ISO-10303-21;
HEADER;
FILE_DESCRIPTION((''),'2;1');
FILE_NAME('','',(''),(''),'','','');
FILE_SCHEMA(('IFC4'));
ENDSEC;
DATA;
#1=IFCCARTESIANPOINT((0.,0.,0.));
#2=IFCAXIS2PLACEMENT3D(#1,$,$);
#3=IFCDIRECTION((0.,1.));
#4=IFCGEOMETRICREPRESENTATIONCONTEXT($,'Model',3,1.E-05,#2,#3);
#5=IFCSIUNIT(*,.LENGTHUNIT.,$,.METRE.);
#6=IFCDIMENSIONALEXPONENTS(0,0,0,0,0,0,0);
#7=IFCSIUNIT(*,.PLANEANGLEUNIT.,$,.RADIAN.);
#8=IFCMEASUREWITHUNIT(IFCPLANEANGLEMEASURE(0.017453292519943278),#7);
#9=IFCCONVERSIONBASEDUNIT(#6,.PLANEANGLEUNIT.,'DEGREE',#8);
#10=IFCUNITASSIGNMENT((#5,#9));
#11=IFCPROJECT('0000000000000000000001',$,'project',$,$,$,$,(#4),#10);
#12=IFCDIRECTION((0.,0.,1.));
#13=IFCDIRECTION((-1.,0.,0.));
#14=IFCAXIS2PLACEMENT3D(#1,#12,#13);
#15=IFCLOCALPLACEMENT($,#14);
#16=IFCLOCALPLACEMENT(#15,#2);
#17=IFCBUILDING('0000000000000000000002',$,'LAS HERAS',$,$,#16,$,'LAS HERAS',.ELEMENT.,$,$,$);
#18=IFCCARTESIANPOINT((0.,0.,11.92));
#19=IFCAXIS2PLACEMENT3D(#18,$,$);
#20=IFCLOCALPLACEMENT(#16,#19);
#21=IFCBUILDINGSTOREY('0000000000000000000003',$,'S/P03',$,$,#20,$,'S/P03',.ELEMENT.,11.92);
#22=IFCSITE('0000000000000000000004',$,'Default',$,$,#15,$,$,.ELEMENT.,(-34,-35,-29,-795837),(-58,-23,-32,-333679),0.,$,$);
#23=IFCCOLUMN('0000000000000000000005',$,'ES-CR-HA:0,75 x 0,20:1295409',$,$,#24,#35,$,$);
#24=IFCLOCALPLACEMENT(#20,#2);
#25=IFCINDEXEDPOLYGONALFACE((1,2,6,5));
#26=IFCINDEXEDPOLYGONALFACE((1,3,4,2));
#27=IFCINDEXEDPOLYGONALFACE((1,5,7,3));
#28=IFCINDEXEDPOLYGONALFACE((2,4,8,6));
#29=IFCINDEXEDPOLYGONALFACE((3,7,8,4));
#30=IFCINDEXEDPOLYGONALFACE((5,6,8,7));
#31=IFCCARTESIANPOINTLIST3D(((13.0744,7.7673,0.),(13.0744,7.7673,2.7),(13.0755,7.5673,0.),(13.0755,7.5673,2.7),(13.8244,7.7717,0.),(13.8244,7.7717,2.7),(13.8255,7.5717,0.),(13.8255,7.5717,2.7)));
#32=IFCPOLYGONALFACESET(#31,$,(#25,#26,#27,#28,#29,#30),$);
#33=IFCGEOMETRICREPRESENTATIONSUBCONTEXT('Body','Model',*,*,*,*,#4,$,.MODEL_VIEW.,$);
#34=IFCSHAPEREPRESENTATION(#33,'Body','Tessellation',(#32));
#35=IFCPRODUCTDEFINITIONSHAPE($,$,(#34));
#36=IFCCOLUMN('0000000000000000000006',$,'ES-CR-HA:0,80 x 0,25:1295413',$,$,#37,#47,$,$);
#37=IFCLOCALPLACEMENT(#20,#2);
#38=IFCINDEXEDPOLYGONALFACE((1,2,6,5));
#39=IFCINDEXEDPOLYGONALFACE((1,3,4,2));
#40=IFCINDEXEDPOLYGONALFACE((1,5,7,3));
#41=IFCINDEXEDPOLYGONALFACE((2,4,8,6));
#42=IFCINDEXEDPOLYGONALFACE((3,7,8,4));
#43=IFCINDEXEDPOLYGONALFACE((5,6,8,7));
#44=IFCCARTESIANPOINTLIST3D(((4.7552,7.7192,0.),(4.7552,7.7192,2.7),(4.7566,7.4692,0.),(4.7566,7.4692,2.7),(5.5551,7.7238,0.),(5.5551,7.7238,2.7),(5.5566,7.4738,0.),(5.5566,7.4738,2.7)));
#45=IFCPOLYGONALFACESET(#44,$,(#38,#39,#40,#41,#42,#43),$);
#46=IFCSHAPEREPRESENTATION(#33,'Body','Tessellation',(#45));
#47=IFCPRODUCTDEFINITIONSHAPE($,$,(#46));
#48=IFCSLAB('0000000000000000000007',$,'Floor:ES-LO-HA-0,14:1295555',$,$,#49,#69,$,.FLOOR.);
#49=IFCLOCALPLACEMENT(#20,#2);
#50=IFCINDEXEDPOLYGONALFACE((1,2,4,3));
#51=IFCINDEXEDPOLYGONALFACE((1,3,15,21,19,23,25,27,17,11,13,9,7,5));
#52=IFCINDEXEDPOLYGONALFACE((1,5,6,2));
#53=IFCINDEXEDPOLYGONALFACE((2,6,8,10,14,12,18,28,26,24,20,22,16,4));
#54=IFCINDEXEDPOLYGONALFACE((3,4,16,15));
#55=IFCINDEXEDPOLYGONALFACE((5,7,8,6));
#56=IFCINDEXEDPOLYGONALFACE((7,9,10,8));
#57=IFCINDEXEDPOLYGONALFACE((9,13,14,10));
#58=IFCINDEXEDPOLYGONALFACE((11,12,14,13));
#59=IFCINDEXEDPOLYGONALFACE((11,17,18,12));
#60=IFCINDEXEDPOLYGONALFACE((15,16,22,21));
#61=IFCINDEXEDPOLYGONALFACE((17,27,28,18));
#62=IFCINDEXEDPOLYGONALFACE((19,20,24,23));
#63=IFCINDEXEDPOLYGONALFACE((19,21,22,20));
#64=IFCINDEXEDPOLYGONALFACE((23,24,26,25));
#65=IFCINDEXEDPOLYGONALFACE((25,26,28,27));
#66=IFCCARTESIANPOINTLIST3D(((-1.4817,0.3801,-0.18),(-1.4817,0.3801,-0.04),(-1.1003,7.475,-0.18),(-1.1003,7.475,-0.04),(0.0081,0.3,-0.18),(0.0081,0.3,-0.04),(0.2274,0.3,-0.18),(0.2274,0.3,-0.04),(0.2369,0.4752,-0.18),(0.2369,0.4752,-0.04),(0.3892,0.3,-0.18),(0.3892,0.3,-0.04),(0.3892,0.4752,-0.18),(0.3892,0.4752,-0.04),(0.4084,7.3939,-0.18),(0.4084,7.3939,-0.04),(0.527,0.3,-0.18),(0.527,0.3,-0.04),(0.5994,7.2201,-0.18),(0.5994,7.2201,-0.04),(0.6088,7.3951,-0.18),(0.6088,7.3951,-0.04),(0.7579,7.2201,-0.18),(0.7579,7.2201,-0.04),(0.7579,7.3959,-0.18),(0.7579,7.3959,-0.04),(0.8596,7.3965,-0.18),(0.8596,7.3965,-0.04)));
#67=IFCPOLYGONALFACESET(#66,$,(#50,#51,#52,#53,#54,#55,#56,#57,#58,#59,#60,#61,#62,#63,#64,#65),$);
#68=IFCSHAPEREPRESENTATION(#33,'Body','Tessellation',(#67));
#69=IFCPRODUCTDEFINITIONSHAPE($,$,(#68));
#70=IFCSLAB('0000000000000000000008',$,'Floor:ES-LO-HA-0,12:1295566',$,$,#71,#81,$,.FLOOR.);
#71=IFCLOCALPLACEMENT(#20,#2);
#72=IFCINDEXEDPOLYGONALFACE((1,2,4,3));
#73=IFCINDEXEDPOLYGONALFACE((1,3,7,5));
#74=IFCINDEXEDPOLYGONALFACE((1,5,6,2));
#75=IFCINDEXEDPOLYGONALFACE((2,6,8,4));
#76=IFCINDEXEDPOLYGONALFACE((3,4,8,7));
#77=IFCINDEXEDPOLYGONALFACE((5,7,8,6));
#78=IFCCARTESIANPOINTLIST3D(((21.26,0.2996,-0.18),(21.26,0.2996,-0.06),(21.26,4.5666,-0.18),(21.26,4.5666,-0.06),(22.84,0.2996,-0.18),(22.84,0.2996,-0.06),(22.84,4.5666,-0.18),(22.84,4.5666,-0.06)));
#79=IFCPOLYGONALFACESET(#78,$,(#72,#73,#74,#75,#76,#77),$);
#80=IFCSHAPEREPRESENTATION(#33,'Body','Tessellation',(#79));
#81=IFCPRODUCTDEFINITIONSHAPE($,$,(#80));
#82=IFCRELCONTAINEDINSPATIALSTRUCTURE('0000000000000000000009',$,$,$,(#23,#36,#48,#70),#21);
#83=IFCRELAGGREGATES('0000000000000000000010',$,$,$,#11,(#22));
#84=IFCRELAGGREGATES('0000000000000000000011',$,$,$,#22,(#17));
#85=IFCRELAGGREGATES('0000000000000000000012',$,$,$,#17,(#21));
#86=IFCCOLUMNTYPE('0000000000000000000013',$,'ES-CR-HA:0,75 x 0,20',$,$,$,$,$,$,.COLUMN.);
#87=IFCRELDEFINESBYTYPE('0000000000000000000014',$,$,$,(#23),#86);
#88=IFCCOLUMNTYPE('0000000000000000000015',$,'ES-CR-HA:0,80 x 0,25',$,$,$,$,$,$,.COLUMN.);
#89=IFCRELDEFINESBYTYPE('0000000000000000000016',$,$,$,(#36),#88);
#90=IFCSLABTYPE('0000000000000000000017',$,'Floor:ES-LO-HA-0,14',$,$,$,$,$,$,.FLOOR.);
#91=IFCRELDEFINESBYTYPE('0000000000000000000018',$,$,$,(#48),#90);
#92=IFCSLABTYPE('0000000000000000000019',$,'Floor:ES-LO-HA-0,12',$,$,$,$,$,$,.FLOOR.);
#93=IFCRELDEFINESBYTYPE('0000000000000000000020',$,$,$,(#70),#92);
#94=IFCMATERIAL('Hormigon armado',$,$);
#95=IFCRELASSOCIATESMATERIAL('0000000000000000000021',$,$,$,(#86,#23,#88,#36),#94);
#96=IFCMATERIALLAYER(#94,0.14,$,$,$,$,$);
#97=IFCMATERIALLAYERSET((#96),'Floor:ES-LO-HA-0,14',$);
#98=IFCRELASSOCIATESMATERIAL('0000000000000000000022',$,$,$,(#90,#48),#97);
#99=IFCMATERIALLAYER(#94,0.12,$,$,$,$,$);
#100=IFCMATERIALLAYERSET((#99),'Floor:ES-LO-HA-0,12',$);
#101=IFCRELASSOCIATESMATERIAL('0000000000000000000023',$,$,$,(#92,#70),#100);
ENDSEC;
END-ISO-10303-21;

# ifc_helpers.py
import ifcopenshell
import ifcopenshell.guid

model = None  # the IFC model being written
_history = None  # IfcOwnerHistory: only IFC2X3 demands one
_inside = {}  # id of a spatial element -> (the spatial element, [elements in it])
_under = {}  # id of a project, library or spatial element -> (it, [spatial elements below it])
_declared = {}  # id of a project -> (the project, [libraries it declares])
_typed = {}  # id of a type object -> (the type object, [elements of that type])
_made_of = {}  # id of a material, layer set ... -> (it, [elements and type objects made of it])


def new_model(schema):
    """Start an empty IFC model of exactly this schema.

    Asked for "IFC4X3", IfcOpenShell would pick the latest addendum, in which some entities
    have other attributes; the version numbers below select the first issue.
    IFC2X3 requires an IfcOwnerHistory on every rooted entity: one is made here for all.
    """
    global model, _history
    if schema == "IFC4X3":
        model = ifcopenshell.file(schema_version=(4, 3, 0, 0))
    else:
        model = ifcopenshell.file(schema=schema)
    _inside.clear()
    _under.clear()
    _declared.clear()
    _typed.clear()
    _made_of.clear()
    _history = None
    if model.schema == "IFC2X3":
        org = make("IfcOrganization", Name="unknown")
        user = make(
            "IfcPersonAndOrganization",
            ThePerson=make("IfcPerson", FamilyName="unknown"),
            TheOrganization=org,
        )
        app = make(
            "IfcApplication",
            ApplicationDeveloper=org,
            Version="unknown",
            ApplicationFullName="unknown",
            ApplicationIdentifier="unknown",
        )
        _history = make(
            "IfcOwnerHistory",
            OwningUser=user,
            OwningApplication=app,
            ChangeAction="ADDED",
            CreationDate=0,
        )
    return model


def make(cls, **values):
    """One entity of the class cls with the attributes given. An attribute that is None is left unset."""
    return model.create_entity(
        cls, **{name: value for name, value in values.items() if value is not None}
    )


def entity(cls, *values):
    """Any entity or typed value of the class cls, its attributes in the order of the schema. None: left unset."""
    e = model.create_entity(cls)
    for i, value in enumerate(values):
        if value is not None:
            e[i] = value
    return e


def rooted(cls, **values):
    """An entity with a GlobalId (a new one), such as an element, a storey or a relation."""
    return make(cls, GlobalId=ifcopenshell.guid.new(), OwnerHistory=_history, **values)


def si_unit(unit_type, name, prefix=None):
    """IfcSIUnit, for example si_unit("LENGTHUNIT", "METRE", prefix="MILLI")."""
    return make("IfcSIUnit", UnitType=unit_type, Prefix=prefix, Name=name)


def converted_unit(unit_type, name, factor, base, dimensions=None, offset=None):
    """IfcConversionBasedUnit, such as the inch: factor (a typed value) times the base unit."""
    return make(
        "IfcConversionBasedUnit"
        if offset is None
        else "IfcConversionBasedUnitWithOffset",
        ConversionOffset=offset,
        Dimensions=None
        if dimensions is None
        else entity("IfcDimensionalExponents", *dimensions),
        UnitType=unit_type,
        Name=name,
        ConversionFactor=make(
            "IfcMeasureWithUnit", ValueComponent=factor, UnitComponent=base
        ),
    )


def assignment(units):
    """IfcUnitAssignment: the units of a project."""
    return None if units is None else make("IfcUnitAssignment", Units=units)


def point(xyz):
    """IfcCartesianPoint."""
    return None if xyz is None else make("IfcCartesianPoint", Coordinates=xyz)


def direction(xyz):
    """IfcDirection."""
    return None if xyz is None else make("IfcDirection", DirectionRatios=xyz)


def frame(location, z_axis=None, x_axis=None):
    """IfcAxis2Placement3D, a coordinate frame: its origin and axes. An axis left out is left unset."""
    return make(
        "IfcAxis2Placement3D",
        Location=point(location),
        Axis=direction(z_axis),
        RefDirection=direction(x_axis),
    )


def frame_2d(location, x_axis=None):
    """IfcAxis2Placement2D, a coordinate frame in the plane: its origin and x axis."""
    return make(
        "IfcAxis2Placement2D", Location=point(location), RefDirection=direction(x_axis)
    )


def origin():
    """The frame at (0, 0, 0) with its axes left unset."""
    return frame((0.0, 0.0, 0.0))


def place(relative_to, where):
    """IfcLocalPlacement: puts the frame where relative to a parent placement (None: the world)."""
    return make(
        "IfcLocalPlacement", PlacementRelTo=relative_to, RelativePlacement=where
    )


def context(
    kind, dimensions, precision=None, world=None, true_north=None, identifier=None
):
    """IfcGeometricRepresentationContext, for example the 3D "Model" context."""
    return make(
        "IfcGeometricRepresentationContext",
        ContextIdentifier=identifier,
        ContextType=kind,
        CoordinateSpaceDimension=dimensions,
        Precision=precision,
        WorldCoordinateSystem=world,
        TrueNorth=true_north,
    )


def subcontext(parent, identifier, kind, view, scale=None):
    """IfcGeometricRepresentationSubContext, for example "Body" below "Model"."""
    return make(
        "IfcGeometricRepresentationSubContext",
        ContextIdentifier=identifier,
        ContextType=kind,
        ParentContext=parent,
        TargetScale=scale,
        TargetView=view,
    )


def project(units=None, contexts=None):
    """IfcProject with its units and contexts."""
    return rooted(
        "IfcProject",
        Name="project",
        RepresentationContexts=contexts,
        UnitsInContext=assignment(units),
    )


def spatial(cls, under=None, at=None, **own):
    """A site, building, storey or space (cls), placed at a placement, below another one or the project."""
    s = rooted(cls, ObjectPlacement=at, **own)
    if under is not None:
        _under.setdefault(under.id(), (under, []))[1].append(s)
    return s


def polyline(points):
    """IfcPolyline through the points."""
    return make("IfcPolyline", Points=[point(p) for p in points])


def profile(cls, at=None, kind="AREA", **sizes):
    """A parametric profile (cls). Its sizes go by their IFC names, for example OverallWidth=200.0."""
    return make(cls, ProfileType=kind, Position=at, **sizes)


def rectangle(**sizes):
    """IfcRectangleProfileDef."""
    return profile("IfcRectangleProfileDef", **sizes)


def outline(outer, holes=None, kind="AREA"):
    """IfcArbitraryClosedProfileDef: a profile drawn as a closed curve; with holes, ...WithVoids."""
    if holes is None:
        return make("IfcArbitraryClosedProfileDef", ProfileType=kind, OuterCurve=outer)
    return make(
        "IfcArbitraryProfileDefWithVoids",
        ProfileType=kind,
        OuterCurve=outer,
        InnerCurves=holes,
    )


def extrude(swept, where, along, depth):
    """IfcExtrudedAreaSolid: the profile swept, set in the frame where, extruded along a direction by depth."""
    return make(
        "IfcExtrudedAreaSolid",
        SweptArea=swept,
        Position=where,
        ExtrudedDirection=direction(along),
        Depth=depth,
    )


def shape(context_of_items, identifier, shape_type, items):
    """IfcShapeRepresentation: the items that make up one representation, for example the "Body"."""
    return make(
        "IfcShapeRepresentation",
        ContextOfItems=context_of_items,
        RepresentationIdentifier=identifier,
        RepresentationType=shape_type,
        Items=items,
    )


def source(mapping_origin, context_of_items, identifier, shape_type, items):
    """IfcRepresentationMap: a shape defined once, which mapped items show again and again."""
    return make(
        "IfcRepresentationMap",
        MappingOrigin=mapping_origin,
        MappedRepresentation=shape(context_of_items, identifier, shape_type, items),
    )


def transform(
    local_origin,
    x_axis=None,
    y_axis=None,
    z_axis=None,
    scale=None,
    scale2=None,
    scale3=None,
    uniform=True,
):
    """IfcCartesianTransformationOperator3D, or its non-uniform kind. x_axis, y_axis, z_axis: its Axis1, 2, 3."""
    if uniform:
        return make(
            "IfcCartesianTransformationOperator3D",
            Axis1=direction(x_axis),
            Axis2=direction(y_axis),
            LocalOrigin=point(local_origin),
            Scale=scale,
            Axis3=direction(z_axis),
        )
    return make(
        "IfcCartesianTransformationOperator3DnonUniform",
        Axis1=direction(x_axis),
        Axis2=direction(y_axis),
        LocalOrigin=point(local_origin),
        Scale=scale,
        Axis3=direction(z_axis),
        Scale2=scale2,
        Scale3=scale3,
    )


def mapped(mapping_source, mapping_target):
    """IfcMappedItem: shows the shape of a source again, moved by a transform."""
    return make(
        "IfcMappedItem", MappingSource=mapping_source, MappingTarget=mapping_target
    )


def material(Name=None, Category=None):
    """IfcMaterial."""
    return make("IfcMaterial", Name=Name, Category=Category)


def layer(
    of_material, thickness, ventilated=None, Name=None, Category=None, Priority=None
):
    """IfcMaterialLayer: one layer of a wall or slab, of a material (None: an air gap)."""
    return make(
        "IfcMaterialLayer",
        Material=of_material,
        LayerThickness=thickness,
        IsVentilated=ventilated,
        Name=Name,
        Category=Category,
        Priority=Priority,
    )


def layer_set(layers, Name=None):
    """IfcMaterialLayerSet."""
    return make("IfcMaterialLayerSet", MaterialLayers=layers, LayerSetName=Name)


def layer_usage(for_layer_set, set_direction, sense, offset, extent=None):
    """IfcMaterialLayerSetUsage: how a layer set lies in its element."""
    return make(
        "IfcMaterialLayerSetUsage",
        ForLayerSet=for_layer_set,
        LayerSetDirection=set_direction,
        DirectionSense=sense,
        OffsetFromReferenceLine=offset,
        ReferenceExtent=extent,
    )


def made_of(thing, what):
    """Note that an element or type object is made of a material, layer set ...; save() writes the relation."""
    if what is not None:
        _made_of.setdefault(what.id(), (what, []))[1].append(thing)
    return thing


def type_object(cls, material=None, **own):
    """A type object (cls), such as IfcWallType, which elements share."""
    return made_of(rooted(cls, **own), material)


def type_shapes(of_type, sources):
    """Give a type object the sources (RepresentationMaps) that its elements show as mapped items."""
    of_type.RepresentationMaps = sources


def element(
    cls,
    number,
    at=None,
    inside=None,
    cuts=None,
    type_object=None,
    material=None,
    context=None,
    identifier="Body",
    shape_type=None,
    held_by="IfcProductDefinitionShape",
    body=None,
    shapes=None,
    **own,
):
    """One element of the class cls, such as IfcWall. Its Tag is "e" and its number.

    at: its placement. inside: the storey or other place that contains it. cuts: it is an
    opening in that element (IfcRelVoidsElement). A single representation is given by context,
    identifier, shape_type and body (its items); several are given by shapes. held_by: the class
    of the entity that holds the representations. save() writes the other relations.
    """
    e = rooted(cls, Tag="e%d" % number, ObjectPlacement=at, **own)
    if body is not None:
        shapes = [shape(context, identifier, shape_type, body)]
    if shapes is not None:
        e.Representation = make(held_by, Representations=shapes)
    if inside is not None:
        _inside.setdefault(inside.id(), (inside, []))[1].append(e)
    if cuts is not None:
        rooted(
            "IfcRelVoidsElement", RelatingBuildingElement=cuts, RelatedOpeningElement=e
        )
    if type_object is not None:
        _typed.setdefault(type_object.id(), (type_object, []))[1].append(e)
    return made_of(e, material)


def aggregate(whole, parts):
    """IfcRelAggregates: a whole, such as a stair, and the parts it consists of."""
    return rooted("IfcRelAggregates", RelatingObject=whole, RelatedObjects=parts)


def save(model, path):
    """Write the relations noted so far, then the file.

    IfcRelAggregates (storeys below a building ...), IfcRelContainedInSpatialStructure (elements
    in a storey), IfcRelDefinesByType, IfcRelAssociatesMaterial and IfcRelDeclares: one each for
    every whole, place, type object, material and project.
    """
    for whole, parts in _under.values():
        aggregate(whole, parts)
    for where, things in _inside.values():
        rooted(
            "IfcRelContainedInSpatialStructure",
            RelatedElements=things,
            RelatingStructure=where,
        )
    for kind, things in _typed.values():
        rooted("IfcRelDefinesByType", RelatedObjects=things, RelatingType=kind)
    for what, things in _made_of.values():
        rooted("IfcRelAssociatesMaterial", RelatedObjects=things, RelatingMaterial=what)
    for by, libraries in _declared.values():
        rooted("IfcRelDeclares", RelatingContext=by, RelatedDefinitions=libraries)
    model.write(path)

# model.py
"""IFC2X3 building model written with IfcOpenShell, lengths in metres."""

from ifc_helpers import new_model, entity, si_unit, converted_unit, direction, frame, frame_2d, origin, place, context, subcontext, project, spatial, polyline, rectangle, outline, extrude, source, transform, mapped, material, layer, layer_set, layer_usage, type_object, type_shapes, element, save


model = new_model("IFC2X3")

# Units and contexts
model_context = context("Model", 3, precision=1e-05, world=origin(), true_north=direction((0.0, 1.0)))
body_context = subcontext(model_context, "Body", "Model", "MODEL_VIEW")
ifc_project = project(units=[si_unit("LENGTHUNIT", "METRE"), converted_unit("PLANEANGLEUNIT", "DEGREE", entity("IfcPlaneAngleMeasure", 0.017453292519943278), si_unit("PLANEANGLEUNIT", "RADIAN"), dimensions=[0, 0, 0, 0, 0, 0, 0])], contexts=[model_context])

# Site, building, storey
site_placement = place(None, frame((0.0, 0.0, 0.0), z_axis=(0.0, 0.0, 1.0), x_axis=(-1.0, 0.0, 0.0)))
site = spatial("IfcSite", under=ifc_project, at=site_placement, Name="Default", CompositionType="ELEMENT", RefLatitude=(-34, -35, -29, -795837), RefLongitude=(-58, -23, -32, -333679), RefElevation=0.0)
building_placement = place(site_placement, origin())
building = spatial("IfcBuilding", under=site, at=building_placement, Name="LAS HERAS", LongName="LAS HERAS", CompositionType="ELEMENT")
storey_placement = place(building_placement, frame((0.0, 0.0, 11.92)))
storey = spatial("IfcBuildingStorey", under=building, at=storey_placement, Name="S/P03", LongName="S/P03", CompositionType="ELEMENT", Elevation=11.92)

# Columns
ifc_material = material(Name="Hormigon armado")
column_type_1 = type_object("IfcColumnType", Name="ES-CR-HA:0,75 x 0,20", PredefinedType="COLUMN", material=ifc_material)
shared_shape_1 = source(origin(), body_context, "Body", "SweptSolid", [
    extrude(rectangle(XDim=0.75, YDim=0.2, at=frame_2d((0.0, 0.0), x_axis=(1.0, 0.0))), frame((13.4499, 7.6695, 11.92), z_axis=(0.0, 0.0, 1.0), x_axis=(-0.999983, -0.005788, 0.0)), (0.0, 0.0, 1.0), 2.7),
])
type_shapes(column_type_1, [shared_shape_1])
column_1_placement = place(storey_placement, frame((0.0, 0.0, -11.92)))
element("IfcColumn", 1, at=column_1_placement, inside=storey, type_object=column_type_1, material=ifc_material, Name="ES-CR-HA:0,75 x 0,20:1295409", context=body_context, shape_type="MappedRepresentation", body=[
    mapped(shared_shape_1, transform((0.0, 0.0, 0.0), scale=1.0)),
])
column_type_2 = type_object("IfcColumnType", Name="ES-CR-HA:0,80 x 0,25", PredefinedType="COLUMN", material=ifc_material)
shared_shape_2 = source(origin(), body_context, "Body", "SweptSolid", [
    extrude(rectangle(XDim=0.8, YDim=0.25, at=frame_2d((0.0, 0.0), x_axis=(1.0, 0.0))), frame((5.1559, 7.5965, 11.92), z_axis=(0.0, 0.0, 1.0), x_axis=(-0.999983, -0.005788, 0.0)), (0.0, 0.0, 1.0), 2.7),
])
type_shapes(column_type_2, [shared_shape_2])
column_2_placement = place(storey_placement, frame((0.0, 0.0, -11.92)))
element("IfcColumn", 2, at=column_2_placement, inside=storey, type_object=column_type_2, material=ifc_material, Name="ES-CR-HA:0,80 x 0,25:1295413", context=body_context, shape_type="MappedRepresentation", body=[
    mapped(shared_shape_2, transform((0.0, 0.0, 0.0), scale=1.0)),
])

# Slab, openings
ifc_layer_1 = layer(ifc_material, 0.14)
ifc_layer_set_1 = layer_set([ifc_layer_1], Name="Floor:ES-LO-HA-0,14")
ifc_layer_usage_1 = layer_usage(ifc_layer_set_1, "AXIS3", "POSITIVE", 0.0)
slab_type_1 = type_object("IfcSlabType", Name="Floor:ES-LO-HA-0,14", PredefinedType="FLOOR", material=ifc_layer_set_1)
slab_1_placement = place(storey_placement, origin())
slab_1 = element("IfcSlab", 3, at=slab_1_placement, inside=storey, type_object=slab_type_1, material=ifc_layer_usage_1, Name="Floor:ES-LO-HA-0,14:1295555", PredefinedType="FLOOR", context=body_context, shape_type="SweptSolid", body=[
    extrude(outline(polyline([(-0.2993, -3.5591), (-0.1615, -3.5591), (-0.1615, -3.3839), (-0.0091, -3.3839), (0.0003, -3.5591), (0.2196, -3.5591), (1.7094, -3.479), (1.328, 3.6159), (-0.1807, 3.5348), (-0.3811, 3.536), (-0.3717, 3.3611), (-0.5302, 3.3611), (-0.5302, 3.5368), (-0.6319, 3.5374), (-0.2993, -3.5591)])), frame((0.2277, 3.8591, -0.04), z_axis=(0.0, 0.0, -1.0), x_axis=(-1.0, 0.0, 0.0)), (0.0, 0.0, 1.0), 0.14),
])
opening_1_placement = place(slab_1_placement, origin())
element("IfcOpeningElement", 4, at=opening_1_placement, cuts=slab_1, ObjectType="Opening", context=body_context, shape_type="SweptSolid", body=[
    extrude(outline(polyline([(0.2369, 0.4752), (0.2274, 0.3), (0.3892, 0.3), (0.3892, 0.4752), (0.2369, 0.4752)])), frame((0.0, 0.0, -0.04)), (0.0, 0.0, -1.0), 0.14),
])
opening_2_placement = place(slab_1_placement, origin())
element("IfcOpeningElement", 5, at=opening_2_placement, cuts=slab_1, ObjectType="Opening", context=body_context, shape_type="SweptSolid", body=[
    extrude(outline(polyline([(0.7579, 7.2201), (0.7579, 7.3959), (0.6088, 7.3951), (0.5994, 7.2201), (0.7579, 7.2201)])), frame((0.0, 0.0, -0.04)), (0.0, 0.0, -1.0), 0.14),
])

# Slab
ifc_layer_2 = layer(ifc_material, 0.12)
ifc_layer_set_2 = layer_set([ifc_layer_2], Name="Floor:ES-LO-HA-0,12")
ifc_layer_usage_2 = layer_usage(ifc_layer_set_2, "AXIS3", "POSITIVE", 0.0)
slab_type_2 = type_object("IfcSlabType", Name="Floor:ES-LO-HA-0,12", PredefinedType="FLOOR", material=ifc_layer_set_2)
slab_2_placement = place(storey_placement, origin())
element("IfcSlab", 6, at=slab_2_placement, inside=storey, type_object=slab_type_2, material=ifc_layer_usage_2, Name="Floor:ES-LO-HA-0,12:1295566", PredefinedType="FLOOR", context=body_context, shape_type="SweptSolid", body=[
    extrude(rectangle(XDim=4.2671, YDim=1.58, at=frame_2d((0.0, 0.0), x_axis=(1.0, 0.0))), frame((22.05, 2.4331, -0.06), z_axis=(0.0, 0.0, -1.0), x_axis=(0.0, 1.0, 0.0)), (0.0, 0.0, 1.0), 0.12),
])

save(model, "model.ifc")
